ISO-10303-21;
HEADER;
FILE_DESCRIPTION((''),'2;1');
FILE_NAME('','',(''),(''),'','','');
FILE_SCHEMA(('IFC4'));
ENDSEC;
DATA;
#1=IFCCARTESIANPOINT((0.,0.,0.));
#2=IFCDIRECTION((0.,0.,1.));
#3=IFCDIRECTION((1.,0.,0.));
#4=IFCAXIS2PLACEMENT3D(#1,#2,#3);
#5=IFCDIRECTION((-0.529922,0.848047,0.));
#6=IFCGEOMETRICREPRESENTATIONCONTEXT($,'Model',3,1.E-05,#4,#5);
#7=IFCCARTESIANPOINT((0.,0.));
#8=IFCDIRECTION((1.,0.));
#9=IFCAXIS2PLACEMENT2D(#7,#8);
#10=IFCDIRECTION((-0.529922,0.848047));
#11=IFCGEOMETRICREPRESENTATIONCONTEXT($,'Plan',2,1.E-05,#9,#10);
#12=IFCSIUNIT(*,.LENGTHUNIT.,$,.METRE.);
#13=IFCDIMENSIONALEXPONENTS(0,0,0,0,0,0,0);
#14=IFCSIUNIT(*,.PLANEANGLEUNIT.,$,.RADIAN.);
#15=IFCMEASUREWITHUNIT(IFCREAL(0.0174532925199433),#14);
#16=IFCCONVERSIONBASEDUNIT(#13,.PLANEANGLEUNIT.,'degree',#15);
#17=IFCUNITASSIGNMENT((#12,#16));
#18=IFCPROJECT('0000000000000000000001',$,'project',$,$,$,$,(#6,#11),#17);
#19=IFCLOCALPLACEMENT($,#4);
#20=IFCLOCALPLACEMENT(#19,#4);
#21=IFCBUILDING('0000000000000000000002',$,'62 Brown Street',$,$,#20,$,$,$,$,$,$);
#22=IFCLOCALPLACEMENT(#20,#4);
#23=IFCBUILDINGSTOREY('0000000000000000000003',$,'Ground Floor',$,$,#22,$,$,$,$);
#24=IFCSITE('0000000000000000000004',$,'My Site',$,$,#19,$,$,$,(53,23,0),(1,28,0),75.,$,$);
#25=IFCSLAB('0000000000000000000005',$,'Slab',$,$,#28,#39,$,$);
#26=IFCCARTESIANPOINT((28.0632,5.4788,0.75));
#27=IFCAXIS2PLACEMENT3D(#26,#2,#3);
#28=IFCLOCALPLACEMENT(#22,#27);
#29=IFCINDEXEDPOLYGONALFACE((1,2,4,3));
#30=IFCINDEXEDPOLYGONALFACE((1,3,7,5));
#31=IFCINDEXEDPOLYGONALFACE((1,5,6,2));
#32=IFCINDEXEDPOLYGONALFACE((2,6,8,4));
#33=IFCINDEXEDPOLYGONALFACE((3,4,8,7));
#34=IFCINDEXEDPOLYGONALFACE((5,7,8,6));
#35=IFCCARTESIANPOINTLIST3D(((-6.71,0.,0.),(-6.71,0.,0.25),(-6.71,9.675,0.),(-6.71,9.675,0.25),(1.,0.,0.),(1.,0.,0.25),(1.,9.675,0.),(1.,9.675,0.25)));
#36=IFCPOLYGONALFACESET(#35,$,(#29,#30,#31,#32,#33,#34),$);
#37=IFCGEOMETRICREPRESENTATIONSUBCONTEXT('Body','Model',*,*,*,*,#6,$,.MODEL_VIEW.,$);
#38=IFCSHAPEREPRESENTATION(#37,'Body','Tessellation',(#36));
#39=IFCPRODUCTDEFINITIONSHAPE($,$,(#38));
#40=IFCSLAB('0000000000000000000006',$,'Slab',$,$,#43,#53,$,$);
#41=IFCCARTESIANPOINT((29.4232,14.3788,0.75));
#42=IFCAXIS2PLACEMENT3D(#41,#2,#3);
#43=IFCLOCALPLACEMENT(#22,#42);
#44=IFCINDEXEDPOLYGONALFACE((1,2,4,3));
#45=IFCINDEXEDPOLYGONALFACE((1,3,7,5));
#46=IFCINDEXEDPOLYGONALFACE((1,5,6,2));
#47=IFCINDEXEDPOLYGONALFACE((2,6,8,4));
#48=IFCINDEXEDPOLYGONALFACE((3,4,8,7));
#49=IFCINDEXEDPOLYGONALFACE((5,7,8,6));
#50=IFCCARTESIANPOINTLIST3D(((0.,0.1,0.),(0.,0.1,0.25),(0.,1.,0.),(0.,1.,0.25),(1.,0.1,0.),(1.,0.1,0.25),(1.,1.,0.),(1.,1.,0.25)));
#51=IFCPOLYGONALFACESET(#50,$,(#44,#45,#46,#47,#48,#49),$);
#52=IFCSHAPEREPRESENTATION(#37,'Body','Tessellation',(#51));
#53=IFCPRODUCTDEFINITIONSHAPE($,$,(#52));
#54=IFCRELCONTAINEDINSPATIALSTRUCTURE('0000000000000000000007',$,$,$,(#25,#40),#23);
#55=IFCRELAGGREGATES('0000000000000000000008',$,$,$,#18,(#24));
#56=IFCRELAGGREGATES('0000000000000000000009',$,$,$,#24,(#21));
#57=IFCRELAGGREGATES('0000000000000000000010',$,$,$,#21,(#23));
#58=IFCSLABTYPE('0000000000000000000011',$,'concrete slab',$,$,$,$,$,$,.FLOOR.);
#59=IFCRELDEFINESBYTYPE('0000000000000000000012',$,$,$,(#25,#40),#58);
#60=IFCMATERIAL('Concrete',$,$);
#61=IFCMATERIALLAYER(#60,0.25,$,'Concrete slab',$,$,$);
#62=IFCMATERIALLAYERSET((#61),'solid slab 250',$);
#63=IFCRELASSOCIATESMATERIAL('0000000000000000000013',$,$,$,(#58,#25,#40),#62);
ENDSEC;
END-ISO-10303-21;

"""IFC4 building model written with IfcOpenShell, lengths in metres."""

from ifc_helpers import new_model, entity, si_unit, converted_unit, direction, frame, origin_with_axes, origin_2d_with_axis, place, context, subcontext, project, spatial, line, indexed_curve, outline, extrude, material, layer, layer_set, layer_usage, type_object, element, save


model = new_model("IFC4")

# Units and contexts
model_context = context("Model", 3, precision=1e-05, world=origin_with_axes(), true_north=direction((-0.529922, 0.848047, 0.0)))
plan_context = context("Plan", 2, precision=1e-05, world=origin_2d_with_axis(), true_north=direction((-0.529922, 0.848047)))
body_context_1 = subcontext(model_context, "Body", "Model", "MODEL_VIEW")
ifc_project = project(units=[si_unit("LENGTHUNIT", "METRE"), converted_unit("PLANEANGLEUNIT", "degree", entity("IfcReal", 0.0174532925199433), si_unit("PLANEANGLEUNIT", "RADIAN"), dimensions=[0, 0, 0, 0, 0, 0, 0])], contexts=[model_context, plan_context])

# Site, building, storey
site_placement = place(None, origin_with_axes())
site = spatial("IfcSite", under=ifc_project, at=site_placement, Name="My Site", RefLatitude=(53, 23, 0), RefLongitude=(1, 28, 0), RefElevation=75.0)
building_placement = place(site_placement, origin_with_axes())
building = spatial("IfcBuilding", under=site, at=building_placement, Name="62 Brown Street")
storey_placement = place(building_placement, origin_with_axes())
storey = spatial("IfcBuildingStorey", under=building, at=storey_placement, Name="Ground Floor")

# Shared definitions
ifc_material_1 = material(Name="Concrete")

# Slabs
ifc_layer_1 = layer(ifc_material_1, 0.25, Name="Concrete slab")
ifc_layer_set_1 = layer_set([ifc_layer_1], Name="solid slab 250")
slab_type = type_object("IfcSlabType", Name="concrete slab", PredefinedType="FLOOR", material=ifc_layer_set_1)
ifc_layer_usage_1 = layer_usage(ifc_layer_set_1, "AXIS3", "POSITIVE", 0.0)
slab_1_placement = place(storey_placement, frame((28.0632, 5.4788, 0.75), z_axis=(0.0, 0.0, 1.0), x_axis=(1.0, 0.0, 0.0)))
element("IfcSlab", 1, at=slab_1_placement, inside=storey, type_object=slab_type, material=ifc_layer_usage_1, Name="Slab", context=body_context_1, shape_type="SweptSolid", body=[
    extrude(outline(indexed_curve([(-6.71, 0.0), (-6.71, 9.675), (1.0, 9.675), (1.0, 0.0), (-6.71, 0.0)])), None, (0.0, 0.0, 1.0), 0.25),
])
ifc_layer_usage_2 = layer_usage(ifc_layer_set_1, "AXIS3", "POSITIVE", 0.0)
slab_2_placement = place(storey_placement, frame((29.4232, 14.3788, 0.75), z_axis=(0.0, 0.0, 1.0), x_axis=(1.0, 0.0, 0.0)))
element("IfcSlab", 2, at=slab_2_placement, inside=storey, type_object=slab_type, material=ifc_layer_usage_2, Name="Slab", context=body_context_1, shape_type="SweptSolid", body=[
    extrude(outline(indexed_curve([(1.0, 1.0), (1.0, 0.1), (0.0, 0.1), (0.0, 1.0)], segments=[line(3, 2), line(2, 1), line(1, 4), line(4, 3)], self_intersect=False)), None, (0.0, 0.0, 1.0), 0.25),
])

save(model, "model.ifc")
